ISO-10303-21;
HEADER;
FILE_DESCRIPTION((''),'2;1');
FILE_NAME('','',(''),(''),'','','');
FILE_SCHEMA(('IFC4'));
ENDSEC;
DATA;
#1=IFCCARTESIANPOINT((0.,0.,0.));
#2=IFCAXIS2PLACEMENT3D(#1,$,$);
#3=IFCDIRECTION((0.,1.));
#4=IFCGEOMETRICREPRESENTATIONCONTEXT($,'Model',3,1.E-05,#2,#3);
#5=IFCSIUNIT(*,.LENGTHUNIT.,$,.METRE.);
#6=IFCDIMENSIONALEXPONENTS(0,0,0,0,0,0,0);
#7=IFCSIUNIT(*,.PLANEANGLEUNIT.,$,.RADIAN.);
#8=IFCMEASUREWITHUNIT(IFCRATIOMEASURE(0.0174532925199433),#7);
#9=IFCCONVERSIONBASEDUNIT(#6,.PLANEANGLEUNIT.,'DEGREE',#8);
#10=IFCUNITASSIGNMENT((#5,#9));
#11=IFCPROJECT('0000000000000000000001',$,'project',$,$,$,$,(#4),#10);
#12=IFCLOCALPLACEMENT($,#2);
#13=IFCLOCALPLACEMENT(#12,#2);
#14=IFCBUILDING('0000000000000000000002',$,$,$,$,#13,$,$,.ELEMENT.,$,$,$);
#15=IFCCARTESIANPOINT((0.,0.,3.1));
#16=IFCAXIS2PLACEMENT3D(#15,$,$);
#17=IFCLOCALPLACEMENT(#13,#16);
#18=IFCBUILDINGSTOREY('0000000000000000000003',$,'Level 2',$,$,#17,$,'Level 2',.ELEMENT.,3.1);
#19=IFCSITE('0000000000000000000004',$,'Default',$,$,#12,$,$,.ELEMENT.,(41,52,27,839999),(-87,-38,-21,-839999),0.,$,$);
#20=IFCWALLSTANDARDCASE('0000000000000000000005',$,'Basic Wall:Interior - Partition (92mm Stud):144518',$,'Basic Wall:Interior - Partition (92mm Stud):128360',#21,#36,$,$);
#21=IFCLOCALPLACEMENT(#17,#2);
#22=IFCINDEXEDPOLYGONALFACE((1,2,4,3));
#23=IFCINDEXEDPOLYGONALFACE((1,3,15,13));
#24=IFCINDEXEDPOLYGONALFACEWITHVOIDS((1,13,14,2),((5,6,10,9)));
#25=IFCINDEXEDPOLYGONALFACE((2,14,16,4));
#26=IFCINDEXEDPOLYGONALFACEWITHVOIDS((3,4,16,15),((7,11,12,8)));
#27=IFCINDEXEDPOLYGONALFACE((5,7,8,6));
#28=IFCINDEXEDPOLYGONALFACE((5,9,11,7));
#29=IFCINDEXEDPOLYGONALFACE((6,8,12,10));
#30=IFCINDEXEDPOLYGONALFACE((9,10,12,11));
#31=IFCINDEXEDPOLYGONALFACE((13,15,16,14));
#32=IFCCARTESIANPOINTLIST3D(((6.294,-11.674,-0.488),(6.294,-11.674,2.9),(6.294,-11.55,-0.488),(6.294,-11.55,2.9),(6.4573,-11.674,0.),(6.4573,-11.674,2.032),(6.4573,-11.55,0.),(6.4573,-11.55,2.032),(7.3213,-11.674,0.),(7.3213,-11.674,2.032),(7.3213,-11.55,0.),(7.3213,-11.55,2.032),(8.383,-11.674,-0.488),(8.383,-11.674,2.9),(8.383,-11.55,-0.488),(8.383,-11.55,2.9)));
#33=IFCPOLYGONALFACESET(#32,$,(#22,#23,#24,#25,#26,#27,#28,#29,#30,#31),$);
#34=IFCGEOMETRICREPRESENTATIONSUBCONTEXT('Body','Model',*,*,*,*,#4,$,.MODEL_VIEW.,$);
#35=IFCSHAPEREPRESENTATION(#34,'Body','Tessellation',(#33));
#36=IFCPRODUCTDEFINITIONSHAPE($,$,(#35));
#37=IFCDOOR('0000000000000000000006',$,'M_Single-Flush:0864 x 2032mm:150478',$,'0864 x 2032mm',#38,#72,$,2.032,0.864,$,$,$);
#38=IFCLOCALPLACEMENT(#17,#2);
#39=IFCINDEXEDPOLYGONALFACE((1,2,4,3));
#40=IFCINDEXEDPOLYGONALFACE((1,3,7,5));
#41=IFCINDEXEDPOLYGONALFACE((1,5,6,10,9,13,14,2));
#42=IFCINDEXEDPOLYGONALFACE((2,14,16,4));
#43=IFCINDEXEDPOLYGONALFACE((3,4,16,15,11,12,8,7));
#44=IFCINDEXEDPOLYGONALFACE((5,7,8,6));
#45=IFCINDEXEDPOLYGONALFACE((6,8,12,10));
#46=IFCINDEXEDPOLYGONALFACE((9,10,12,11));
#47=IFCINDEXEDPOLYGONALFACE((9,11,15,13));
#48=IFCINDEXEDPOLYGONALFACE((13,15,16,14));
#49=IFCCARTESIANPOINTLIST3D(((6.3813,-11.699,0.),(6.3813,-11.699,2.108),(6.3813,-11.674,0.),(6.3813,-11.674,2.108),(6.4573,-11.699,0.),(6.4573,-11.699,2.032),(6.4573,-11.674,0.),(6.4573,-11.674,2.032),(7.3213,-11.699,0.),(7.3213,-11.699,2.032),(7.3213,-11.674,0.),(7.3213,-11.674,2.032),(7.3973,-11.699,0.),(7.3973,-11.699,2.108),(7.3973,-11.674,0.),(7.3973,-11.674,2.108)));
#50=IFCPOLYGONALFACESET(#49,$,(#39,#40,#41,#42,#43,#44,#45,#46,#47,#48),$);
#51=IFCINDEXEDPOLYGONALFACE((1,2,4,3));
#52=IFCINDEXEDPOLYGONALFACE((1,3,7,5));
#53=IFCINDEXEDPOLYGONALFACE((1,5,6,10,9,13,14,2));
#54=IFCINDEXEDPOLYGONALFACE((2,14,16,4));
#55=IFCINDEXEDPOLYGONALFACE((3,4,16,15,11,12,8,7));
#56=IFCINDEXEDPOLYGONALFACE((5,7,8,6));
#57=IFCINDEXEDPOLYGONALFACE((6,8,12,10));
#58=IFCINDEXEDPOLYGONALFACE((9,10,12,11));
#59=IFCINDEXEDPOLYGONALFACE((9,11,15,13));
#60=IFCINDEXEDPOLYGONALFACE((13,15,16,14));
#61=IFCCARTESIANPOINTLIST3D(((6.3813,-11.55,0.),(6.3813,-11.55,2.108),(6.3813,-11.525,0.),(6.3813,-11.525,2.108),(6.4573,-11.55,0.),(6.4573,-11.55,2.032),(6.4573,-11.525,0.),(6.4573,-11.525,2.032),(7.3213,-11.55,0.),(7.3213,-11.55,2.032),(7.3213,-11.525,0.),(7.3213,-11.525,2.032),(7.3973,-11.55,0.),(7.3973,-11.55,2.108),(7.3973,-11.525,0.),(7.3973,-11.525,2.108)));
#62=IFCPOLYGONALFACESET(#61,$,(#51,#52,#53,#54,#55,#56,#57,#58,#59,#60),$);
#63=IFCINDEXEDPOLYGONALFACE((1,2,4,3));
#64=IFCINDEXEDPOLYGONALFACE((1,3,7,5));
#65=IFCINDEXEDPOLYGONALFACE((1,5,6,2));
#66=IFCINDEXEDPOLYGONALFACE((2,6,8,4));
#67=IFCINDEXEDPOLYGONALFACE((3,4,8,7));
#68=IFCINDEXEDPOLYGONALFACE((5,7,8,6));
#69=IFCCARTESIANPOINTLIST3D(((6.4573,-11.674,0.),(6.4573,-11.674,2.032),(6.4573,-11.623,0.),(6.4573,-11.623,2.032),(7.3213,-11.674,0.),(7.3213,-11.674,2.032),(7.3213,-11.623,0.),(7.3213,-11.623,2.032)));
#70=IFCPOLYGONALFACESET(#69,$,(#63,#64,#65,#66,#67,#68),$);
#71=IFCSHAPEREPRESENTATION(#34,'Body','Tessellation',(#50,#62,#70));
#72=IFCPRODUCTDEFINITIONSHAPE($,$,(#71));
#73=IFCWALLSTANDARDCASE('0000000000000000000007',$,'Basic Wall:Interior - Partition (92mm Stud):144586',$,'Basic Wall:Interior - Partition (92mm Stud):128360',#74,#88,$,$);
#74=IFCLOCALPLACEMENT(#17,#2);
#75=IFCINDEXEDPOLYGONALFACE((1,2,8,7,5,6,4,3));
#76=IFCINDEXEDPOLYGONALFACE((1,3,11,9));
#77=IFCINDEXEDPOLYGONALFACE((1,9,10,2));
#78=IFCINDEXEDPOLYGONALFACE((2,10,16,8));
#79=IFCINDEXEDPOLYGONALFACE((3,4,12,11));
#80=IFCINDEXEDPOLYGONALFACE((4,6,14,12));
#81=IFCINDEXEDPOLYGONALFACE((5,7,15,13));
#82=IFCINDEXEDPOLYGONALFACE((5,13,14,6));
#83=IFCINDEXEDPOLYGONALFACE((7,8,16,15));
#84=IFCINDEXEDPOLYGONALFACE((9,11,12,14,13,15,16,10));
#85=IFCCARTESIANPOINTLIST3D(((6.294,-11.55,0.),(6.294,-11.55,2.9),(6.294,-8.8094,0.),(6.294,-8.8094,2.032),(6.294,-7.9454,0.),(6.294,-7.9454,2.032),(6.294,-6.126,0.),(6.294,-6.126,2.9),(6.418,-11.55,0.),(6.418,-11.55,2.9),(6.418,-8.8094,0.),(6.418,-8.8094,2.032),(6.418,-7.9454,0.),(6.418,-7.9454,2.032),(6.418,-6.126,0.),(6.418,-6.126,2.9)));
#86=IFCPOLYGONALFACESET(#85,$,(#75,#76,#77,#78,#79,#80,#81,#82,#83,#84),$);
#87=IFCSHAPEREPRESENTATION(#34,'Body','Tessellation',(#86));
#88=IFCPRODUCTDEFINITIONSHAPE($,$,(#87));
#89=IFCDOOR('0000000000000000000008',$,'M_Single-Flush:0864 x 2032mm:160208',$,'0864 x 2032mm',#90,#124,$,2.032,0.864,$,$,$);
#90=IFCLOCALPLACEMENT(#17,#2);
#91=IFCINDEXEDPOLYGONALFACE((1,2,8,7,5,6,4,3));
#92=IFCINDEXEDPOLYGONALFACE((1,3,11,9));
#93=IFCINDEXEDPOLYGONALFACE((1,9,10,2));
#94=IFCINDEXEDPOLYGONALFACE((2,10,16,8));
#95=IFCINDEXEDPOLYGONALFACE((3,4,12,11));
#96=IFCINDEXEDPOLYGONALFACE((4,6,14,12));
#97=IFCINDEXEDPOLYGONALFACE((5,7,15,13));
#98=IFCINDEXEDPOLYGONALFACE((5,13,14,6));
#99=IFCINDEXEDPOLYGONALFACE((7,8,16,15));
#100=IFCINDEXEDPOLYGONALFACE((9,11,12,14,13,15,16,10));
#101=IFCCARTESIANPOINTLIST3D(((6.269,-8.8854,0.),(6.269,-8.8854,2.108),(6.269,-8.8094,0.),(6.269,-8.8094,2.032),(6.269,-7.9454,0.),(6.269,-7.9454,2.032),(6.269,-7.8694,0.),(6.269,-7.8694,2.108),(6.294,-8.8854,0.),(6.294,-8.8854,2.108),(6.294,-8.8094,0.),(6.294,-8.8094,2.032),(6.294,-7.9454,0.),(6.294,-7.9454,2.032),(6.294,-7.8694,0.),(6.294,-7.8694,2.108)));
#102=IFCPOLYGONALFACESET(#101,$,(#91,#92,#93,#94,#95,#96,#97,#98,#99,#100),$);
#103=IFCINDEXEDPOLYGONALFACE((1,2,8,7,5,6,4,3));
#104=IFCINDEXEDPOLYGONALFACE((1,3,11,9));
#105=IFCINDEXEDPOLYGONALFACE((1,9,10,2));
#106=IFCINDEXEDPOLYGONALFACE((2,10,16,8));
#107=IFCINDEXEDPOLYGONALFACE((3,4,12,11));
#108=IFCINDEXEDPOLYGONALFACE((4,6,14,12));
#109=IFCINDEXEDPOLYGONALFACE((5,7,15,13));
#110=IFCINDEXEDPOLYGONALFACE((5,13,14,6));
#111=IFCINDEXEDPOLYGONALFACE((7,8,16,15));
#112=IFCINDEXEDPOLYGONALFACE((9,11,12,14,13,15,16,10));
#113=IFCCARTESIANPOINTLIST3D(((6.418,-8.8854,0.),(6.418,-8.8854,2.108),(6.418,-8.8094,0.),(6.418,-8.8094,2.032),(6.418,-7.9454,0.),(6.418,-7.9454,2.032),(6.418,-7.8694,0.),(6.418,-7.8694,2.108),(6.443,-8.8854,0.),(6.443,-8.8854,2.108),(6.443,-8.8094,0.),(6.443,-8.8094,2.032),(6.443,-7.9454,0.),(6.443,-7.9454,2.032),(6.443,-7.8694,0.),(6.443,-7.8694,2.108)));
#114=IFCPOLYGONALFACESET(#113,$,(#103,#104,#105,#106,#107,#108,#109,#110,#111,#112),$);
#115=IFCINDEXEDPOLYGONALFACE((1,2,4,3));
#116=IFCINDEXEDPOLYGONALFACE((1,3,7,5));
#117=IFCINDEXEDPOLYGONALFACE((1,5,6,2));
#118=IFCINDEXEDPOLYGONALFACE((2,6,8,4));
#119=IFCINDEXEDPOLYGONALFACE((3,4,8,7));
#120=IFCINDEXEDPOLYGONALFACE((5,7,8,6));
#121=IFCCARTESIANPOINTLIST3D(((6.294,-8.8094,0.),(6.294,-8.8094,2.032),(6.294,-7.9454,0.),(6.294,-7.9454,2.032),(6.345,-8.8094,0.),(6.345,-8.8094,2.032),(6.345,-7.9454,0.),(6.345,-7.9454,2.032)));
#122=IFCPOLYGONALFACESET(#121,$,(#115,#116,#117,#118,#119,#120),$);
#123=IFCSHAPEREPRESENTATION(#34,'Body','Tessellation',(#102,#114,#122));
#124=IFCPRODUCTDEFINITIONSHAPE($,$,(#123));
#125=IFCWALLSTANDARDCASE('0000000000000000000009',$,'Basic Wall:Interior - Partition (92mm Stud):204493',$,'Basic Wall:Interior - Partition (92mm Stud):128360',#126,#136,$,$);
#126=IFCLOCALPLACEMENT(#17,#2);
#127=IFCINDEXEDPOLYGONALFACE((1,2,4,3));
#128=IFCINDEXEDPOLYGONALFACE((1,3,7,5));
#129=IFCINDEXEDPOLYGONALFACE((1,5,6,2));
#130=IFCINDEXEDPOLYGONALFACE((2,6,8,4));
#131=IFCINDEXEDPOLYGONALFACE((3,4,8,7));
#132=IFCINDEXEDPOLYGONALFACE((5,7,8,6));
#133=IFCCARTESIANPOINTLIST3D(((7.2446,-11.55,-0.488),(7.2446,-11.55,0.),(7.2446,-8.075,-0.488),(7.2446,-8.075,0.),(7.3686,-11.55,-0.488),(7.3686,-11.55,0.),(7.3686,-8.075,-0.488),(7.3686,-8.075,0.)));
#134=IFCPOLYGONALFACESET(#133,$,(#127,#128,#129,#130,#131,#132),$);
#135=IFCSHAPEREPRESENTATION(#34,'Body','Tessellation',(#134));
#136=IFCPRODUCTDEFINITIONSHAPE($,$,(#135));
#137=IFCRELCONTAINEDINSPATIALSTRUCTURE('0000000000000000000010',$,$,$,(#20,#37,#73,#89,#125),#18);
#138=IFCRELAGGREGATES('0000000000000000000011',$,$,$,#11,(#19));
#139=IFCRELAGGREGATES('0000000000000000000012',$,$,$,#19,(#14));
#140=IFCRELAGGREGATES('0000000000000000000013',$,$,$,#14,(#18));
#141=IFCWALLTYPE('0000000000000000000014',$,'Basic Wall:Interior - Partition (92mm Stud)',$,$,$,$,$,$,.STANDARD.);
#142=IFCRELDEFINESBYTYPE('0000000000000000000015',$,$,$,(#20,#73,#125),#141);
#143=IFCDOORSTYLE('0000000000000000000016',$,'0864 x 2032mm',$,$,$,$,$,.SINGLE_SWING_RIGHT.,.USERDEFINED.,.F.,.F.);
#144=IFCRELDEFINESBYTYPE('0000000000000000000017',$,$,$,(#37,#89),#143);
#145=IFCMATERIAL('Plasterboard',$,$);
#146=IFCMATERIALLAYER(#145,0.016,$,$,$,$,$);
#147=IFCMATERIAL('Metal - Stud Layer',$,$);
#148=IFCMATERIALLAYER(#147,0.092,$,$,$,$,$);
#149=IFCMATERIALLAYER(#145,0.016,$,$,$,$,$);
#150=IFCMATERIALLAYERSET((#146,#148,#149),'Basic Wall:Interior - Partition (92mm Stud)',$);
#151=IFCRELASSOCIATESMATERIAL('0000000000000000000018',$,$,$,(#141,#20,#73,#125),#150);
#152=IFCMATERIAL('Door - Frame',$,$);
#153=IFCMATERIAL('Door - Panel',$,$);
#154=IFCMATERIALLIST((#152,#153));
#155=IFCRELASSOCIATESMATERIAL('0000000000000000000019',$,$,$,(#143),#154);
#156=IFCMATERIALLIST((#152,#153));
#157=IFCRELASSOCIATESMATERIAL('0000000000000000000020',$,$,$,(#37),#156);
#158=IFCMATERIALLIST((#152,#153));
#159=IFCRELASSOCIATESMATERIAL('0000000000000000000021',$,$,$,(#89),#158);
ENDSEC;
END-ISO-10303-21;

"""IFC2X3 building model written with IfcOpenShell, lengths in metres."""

from ifc_helpers import new_model, entity, si_unit, converted_unit, direction, frame, frame_2d, origin, origin_2d_with_axis, place, context, subcontext, project, spatial, polyline, rectangle, outline, extrude, source, transform, mapped, material, material_list, layer, layer_set, layer_usage, type_object, type_shapes, element, fill, save


model = new_model("IFC2X3")

# Units and contexts
model_context = context("Model", 3, precision=1e-05, world=origin(), true_north=direction((0.0, 1.0)))
body_context = subcontext(model_context, "Body", "Model", "MODEL_VIEW")
ifc_project = project(units=[si_unit("LENGTHUNIT", "METRE"), converted_unit("PLANEANGLEUNIT", "DEGREE", entity("IfcRatioMeasure", 0.0174532925199433), si_unit("PLANEANGLEUNIT", "RADIAN"), dimensions=[0, 0, 0, 0, 0, 0, 0])], contexts=[model_context])

# Site, building, storey
site_placement = place(None, origin())
site = spatial("IfcSite", under=ifc_project, at=site_placement, Name="Default", CompositionType="ELEMENT", RefLatitude=(41, 52, 27, 839999), RefLongitude=(-87, -38, -21, -839999), RefElevation=0.0)
building_placement = place(site_placement, origin())
building = spatial("IfcBuilding", under=site, at=building_placement, CompositionType="ELEMENT")
storey_placement = place(building_placement, frame((0.0, 0.0, 3.1)))
storey = spatial("IfcBuildingStorey", under=building, at=storey_placement, Name="Level 2", LongName="Level 2", CompositionType="ELEMENT", Elevation=3.1)

# Shared definitions
ifc_material_1 = material(Name="Metal - Stud Layer")
ifc_material_2 = material(Name="Plasterboard")

# Wall, opening, door
ifc_layer_1 = layer(ifc_material_2, 0.016)
ifc_layer_2 = layer(ifc_material_1, 0.092)
ifc_layer_3 = layer(ifc_material_2, 0.016)
ifc_layer_set_1 = layer_set([ifc_layer_1, ifc_layer_2, ifc_layer_3], Name="Basic Wall:Interior - Partition (92mm Stud)")
ifc_layer_usage_1 = layer_usage(ifc_layer_set_1, "AXIS2", "NEGATIVE", 0.062)
wall_type_1 = type_object("IfcWallType", Name="Basic Wall:Interior - Partition (92mm Stud)", PredefinedType="STANDARD", material=ifc_layer_set_1)
wall_1_placement = place(storey_placement, frame((8.383, -11.612, -0.488), z_axis=(0.0, 0.0, 1.0), x_axis=(-1.0, 0.0, 0.0)))
wall_1 = element("IfcWallStandardCase", 1, at=wall_1_placement, inside=storey, type_object=wall_type_1, material=ifc_layer_usage_1, Name="Basic Wall:Interior - Partition (92mm Stud):144518", ObjectType="Basic Wall:Interior - Partition (92mm Stud):128360", context=body_context, shape_type="SweptSolid", body=[
    extrude(rectangle(XDim=2.089, YDim=0.124, at=frame_2d((1.0445, 0.0), x_axis=(-1.0, 0.0))), origin(), (0.0, 0.0, 1.0), 3.388),
])
opening_1_placement = place(wall_1_placement, frame((1.0617, -0.062, 0.488)))
opening_1 = element("IfcOpeningElement", 2, at=opening_1_placement, cuts=wall_1, ObjectType="Opening", context=body_context, shape_type="SweptSolid", body=[
    extrude(rectangle(XDim=0.864, YDim=2.032, at=frame_2d((1.016, 0.432), x_axis=(0.0, 1.0))), frame((0.0, 0.0, 0.0), z_axis=(0.0, 1.0, 0.0), x_axis=(0.0, 0.0, 1.0)), (0.0, 0.0, 1.0), 0.124),
])
ifc_material_3 = material(Name="Door - Frame")
ifc_material_4 = material(Name="Door - Panel")
ifc_material_list_1 = material_list([ifc_material_3, ifc_material_4])
ifc_material_list_2 = material_list([ifc_material_3, ifc_material_4])
door_style = type_object("IfcDoorStyle", Name="0864 x 2032mm", ConstructionType="USERDEFINED", OperationType="SINGLE_SWING_RIGHT", ParameterTakesPrecedence=False, Sizeable=False, material=ifc_material_list_2)
shared_shape_1 = source(origin(), body_context, "Body", "SweptSolid", [
    extrude(outline(polyline([(-0.508, -1.073), (0.508, -1.073), (0.508, 1.035), (0.432, 1.035), (0.432, -0.997), (-0.432, -0.997), (-0.432, 1.035), (-0.508, 1.035), (-0.508, -1.073)])), frame((0.432, 0.124, 1.035), z_axis=(0.0, 1.0, 0.0), x_axis=(1.0, 0.0, 0.0)), (0.0, 0.0, 1.0), 0.025),
    extrude(outline(polyline([(-1.073, -0.508), (1.035, -0.508), (1.035, -0.432), (-0.997, -0.432), (-0.997, 0.432), (1.035, 0.432), (1.035, 0.508), (-1.073, 0.508), (-1.073, -0.508)])), frame((0.432, -0.025, 1.035), z_axis=(0.0, 1.0, 0.0), x_axis=(0.0, 0.0, -1.0)), (0.0, 0.0, 1.0), 0.025),
    extrude(rectangle(XDim=0.051, YDim=0.864, at=origin_2d_with_axis()), frame((0.432, 0.0985, 0.0), z_axis=(0.0, 0.0, 1.0), x_axis=(0.0, 1.0, 0.0)), (0.0, 0.0, 1.0), 2.032),
])
type_shapes(door_style, [shared_shape_1])
door_1_placement = place(opening_1_placement, origin())
door_1 = element("IfcDoor", 3, at=door_1_placement, inside=storey, type_object=door_style, material=ifc_material_list_1, Name="M_Single-Flush:0864 x 2032mm:150478", ObjectType="0864 x 2032mm", OverallHeight=2.032, OverallWidth=0.864, context=body_context, shape_type="MappedRepresentation", body=[
    mapped(shared_shape_1, transform((0.0, 0.0, 0.0), scale=1.0)),
])
fill(opening_1, door_1)

# Wall, openings, door
ifc_layer_usage_2 = layer_usage(ifc_layer_set_1, "AXIS2", "NEGATIVE", 0.062)
wall_2_placement = place(storey_placement, frame((6.356, -11.55, 0.0), z_axis=(0.0, 0.0, 1.0), x_axis=(0.0, 1.0, 0.0)))
wall_2 = element("IfcWallStandardCase", 4, at=wall_2_placement, inside=storey, type_object=wall_type_1, material=ifc_layer_usage_2, Name="Basic Wall:Interior - Partition (92mm Stud):144586", ObjectType="Basic Wall:Interior - Partition (92mm Stud):128360", context=body_context, shape_type="SweptSolid", body=[
    extrude(rectangle(XDim=5.424, YDim=0.124, at=frame_2d((2.712, 0.0), x_axis=(-1.0, 0.0))), origin(), (0.0, 0.0, 1.0), 2.9),
])
opening_2_placement = place(wall_2_placement, origin())
element("IfcOpeningElement", 5, at=opening_2_placement, cuts=wall_2, ObjectType="Opening", context=body_context, shape_type="SweptSolid", body=[
    extrude(rectangle(XDim=2.032, YDim=0.124, at=frame_2d((0.0, 0.0), x_axis=(0.0, 1.0))), frame((3.962, 0.0626, 1.016), z_axis=(0.0, 1.0, 0.0), x_axis=(1.0, 0.0, 0.0)), (0.0, 0.0, 1.0), 0.762),
])
opening_3_placement = place(wall_2_placement, frame((2.7406, -0.062, 0.0)))
opening_3 = element("IfcOpeningElement", 6, at=opening_3_placement, cuts=wall_2, ObjectType="Opening", context=body_context, shape_type="SweptSolid", body=[
    extrude(rectangle(XDim=0.864, YDim=2.032, at=frame_2d((1.016, 0.432), x_axis=(0.0, 1.0))), frame((0.0, 0.0, 0.0), z_axis=(0.0, 1.0, 0.0), x_axis=(0.0, 0.0, 1.0)), (0.0, 0.0, 1.0), 0.124),
])
ifc_material_list_3 = material_list([ifc_material_3, ifc_material_4])
door_2_placement = place(opening_3_placement, origin())
door_2 = element("IfcDoor", 7, at=door_2_placement, inside=storey, type_object=door_style, material=ifc_material_list_3, Name="M_Single-Flush:0864 x 2032mm:160208", ObjectType="0864 x 2032mm", OverallHeight=2.032, OverallWidth=0.864, context=body_context, shape_type="MappedRepresentation", body=[
    mapped(shared_shape_1, transform((0.0, 0.0, 0.0), scale=1.0)),
])
fill(opening_3, door_2)

# Wall
ifc_layer_usage_3 = layer_usage(ifc_layer_set_1, "AXIS2", "NEGATIVE", 0.062)
wall_3_placement = place(storey_placement, frame((7.3066, -11.55, -0.488), z_axis=(0.0, 0.0, 1.0), x_axis=(0.0, 1.0, 0.0)))
element("IfcWallStandardCase", 8, at=wall_3_placement, inside=storey, type_object=wall_type_1, material=ifc_layer_usage_3, Name="Basic Wall:Interior - Partition (92mm Stud):204493", ObjectType="Basic Wall:Interior - Partition (92mm Stud):128360", context=body_context, shape_type="SweptSolid", body=[
    extrude(rectangle(XDim=3.475, YDim=0.124, at=frame_2d((1.7375, 0.0), x_axis=(-1.0, 0.0))), origin(), (0.0, 0.0, 1.0), 0.488),
])

save(model, "model.ifc")
